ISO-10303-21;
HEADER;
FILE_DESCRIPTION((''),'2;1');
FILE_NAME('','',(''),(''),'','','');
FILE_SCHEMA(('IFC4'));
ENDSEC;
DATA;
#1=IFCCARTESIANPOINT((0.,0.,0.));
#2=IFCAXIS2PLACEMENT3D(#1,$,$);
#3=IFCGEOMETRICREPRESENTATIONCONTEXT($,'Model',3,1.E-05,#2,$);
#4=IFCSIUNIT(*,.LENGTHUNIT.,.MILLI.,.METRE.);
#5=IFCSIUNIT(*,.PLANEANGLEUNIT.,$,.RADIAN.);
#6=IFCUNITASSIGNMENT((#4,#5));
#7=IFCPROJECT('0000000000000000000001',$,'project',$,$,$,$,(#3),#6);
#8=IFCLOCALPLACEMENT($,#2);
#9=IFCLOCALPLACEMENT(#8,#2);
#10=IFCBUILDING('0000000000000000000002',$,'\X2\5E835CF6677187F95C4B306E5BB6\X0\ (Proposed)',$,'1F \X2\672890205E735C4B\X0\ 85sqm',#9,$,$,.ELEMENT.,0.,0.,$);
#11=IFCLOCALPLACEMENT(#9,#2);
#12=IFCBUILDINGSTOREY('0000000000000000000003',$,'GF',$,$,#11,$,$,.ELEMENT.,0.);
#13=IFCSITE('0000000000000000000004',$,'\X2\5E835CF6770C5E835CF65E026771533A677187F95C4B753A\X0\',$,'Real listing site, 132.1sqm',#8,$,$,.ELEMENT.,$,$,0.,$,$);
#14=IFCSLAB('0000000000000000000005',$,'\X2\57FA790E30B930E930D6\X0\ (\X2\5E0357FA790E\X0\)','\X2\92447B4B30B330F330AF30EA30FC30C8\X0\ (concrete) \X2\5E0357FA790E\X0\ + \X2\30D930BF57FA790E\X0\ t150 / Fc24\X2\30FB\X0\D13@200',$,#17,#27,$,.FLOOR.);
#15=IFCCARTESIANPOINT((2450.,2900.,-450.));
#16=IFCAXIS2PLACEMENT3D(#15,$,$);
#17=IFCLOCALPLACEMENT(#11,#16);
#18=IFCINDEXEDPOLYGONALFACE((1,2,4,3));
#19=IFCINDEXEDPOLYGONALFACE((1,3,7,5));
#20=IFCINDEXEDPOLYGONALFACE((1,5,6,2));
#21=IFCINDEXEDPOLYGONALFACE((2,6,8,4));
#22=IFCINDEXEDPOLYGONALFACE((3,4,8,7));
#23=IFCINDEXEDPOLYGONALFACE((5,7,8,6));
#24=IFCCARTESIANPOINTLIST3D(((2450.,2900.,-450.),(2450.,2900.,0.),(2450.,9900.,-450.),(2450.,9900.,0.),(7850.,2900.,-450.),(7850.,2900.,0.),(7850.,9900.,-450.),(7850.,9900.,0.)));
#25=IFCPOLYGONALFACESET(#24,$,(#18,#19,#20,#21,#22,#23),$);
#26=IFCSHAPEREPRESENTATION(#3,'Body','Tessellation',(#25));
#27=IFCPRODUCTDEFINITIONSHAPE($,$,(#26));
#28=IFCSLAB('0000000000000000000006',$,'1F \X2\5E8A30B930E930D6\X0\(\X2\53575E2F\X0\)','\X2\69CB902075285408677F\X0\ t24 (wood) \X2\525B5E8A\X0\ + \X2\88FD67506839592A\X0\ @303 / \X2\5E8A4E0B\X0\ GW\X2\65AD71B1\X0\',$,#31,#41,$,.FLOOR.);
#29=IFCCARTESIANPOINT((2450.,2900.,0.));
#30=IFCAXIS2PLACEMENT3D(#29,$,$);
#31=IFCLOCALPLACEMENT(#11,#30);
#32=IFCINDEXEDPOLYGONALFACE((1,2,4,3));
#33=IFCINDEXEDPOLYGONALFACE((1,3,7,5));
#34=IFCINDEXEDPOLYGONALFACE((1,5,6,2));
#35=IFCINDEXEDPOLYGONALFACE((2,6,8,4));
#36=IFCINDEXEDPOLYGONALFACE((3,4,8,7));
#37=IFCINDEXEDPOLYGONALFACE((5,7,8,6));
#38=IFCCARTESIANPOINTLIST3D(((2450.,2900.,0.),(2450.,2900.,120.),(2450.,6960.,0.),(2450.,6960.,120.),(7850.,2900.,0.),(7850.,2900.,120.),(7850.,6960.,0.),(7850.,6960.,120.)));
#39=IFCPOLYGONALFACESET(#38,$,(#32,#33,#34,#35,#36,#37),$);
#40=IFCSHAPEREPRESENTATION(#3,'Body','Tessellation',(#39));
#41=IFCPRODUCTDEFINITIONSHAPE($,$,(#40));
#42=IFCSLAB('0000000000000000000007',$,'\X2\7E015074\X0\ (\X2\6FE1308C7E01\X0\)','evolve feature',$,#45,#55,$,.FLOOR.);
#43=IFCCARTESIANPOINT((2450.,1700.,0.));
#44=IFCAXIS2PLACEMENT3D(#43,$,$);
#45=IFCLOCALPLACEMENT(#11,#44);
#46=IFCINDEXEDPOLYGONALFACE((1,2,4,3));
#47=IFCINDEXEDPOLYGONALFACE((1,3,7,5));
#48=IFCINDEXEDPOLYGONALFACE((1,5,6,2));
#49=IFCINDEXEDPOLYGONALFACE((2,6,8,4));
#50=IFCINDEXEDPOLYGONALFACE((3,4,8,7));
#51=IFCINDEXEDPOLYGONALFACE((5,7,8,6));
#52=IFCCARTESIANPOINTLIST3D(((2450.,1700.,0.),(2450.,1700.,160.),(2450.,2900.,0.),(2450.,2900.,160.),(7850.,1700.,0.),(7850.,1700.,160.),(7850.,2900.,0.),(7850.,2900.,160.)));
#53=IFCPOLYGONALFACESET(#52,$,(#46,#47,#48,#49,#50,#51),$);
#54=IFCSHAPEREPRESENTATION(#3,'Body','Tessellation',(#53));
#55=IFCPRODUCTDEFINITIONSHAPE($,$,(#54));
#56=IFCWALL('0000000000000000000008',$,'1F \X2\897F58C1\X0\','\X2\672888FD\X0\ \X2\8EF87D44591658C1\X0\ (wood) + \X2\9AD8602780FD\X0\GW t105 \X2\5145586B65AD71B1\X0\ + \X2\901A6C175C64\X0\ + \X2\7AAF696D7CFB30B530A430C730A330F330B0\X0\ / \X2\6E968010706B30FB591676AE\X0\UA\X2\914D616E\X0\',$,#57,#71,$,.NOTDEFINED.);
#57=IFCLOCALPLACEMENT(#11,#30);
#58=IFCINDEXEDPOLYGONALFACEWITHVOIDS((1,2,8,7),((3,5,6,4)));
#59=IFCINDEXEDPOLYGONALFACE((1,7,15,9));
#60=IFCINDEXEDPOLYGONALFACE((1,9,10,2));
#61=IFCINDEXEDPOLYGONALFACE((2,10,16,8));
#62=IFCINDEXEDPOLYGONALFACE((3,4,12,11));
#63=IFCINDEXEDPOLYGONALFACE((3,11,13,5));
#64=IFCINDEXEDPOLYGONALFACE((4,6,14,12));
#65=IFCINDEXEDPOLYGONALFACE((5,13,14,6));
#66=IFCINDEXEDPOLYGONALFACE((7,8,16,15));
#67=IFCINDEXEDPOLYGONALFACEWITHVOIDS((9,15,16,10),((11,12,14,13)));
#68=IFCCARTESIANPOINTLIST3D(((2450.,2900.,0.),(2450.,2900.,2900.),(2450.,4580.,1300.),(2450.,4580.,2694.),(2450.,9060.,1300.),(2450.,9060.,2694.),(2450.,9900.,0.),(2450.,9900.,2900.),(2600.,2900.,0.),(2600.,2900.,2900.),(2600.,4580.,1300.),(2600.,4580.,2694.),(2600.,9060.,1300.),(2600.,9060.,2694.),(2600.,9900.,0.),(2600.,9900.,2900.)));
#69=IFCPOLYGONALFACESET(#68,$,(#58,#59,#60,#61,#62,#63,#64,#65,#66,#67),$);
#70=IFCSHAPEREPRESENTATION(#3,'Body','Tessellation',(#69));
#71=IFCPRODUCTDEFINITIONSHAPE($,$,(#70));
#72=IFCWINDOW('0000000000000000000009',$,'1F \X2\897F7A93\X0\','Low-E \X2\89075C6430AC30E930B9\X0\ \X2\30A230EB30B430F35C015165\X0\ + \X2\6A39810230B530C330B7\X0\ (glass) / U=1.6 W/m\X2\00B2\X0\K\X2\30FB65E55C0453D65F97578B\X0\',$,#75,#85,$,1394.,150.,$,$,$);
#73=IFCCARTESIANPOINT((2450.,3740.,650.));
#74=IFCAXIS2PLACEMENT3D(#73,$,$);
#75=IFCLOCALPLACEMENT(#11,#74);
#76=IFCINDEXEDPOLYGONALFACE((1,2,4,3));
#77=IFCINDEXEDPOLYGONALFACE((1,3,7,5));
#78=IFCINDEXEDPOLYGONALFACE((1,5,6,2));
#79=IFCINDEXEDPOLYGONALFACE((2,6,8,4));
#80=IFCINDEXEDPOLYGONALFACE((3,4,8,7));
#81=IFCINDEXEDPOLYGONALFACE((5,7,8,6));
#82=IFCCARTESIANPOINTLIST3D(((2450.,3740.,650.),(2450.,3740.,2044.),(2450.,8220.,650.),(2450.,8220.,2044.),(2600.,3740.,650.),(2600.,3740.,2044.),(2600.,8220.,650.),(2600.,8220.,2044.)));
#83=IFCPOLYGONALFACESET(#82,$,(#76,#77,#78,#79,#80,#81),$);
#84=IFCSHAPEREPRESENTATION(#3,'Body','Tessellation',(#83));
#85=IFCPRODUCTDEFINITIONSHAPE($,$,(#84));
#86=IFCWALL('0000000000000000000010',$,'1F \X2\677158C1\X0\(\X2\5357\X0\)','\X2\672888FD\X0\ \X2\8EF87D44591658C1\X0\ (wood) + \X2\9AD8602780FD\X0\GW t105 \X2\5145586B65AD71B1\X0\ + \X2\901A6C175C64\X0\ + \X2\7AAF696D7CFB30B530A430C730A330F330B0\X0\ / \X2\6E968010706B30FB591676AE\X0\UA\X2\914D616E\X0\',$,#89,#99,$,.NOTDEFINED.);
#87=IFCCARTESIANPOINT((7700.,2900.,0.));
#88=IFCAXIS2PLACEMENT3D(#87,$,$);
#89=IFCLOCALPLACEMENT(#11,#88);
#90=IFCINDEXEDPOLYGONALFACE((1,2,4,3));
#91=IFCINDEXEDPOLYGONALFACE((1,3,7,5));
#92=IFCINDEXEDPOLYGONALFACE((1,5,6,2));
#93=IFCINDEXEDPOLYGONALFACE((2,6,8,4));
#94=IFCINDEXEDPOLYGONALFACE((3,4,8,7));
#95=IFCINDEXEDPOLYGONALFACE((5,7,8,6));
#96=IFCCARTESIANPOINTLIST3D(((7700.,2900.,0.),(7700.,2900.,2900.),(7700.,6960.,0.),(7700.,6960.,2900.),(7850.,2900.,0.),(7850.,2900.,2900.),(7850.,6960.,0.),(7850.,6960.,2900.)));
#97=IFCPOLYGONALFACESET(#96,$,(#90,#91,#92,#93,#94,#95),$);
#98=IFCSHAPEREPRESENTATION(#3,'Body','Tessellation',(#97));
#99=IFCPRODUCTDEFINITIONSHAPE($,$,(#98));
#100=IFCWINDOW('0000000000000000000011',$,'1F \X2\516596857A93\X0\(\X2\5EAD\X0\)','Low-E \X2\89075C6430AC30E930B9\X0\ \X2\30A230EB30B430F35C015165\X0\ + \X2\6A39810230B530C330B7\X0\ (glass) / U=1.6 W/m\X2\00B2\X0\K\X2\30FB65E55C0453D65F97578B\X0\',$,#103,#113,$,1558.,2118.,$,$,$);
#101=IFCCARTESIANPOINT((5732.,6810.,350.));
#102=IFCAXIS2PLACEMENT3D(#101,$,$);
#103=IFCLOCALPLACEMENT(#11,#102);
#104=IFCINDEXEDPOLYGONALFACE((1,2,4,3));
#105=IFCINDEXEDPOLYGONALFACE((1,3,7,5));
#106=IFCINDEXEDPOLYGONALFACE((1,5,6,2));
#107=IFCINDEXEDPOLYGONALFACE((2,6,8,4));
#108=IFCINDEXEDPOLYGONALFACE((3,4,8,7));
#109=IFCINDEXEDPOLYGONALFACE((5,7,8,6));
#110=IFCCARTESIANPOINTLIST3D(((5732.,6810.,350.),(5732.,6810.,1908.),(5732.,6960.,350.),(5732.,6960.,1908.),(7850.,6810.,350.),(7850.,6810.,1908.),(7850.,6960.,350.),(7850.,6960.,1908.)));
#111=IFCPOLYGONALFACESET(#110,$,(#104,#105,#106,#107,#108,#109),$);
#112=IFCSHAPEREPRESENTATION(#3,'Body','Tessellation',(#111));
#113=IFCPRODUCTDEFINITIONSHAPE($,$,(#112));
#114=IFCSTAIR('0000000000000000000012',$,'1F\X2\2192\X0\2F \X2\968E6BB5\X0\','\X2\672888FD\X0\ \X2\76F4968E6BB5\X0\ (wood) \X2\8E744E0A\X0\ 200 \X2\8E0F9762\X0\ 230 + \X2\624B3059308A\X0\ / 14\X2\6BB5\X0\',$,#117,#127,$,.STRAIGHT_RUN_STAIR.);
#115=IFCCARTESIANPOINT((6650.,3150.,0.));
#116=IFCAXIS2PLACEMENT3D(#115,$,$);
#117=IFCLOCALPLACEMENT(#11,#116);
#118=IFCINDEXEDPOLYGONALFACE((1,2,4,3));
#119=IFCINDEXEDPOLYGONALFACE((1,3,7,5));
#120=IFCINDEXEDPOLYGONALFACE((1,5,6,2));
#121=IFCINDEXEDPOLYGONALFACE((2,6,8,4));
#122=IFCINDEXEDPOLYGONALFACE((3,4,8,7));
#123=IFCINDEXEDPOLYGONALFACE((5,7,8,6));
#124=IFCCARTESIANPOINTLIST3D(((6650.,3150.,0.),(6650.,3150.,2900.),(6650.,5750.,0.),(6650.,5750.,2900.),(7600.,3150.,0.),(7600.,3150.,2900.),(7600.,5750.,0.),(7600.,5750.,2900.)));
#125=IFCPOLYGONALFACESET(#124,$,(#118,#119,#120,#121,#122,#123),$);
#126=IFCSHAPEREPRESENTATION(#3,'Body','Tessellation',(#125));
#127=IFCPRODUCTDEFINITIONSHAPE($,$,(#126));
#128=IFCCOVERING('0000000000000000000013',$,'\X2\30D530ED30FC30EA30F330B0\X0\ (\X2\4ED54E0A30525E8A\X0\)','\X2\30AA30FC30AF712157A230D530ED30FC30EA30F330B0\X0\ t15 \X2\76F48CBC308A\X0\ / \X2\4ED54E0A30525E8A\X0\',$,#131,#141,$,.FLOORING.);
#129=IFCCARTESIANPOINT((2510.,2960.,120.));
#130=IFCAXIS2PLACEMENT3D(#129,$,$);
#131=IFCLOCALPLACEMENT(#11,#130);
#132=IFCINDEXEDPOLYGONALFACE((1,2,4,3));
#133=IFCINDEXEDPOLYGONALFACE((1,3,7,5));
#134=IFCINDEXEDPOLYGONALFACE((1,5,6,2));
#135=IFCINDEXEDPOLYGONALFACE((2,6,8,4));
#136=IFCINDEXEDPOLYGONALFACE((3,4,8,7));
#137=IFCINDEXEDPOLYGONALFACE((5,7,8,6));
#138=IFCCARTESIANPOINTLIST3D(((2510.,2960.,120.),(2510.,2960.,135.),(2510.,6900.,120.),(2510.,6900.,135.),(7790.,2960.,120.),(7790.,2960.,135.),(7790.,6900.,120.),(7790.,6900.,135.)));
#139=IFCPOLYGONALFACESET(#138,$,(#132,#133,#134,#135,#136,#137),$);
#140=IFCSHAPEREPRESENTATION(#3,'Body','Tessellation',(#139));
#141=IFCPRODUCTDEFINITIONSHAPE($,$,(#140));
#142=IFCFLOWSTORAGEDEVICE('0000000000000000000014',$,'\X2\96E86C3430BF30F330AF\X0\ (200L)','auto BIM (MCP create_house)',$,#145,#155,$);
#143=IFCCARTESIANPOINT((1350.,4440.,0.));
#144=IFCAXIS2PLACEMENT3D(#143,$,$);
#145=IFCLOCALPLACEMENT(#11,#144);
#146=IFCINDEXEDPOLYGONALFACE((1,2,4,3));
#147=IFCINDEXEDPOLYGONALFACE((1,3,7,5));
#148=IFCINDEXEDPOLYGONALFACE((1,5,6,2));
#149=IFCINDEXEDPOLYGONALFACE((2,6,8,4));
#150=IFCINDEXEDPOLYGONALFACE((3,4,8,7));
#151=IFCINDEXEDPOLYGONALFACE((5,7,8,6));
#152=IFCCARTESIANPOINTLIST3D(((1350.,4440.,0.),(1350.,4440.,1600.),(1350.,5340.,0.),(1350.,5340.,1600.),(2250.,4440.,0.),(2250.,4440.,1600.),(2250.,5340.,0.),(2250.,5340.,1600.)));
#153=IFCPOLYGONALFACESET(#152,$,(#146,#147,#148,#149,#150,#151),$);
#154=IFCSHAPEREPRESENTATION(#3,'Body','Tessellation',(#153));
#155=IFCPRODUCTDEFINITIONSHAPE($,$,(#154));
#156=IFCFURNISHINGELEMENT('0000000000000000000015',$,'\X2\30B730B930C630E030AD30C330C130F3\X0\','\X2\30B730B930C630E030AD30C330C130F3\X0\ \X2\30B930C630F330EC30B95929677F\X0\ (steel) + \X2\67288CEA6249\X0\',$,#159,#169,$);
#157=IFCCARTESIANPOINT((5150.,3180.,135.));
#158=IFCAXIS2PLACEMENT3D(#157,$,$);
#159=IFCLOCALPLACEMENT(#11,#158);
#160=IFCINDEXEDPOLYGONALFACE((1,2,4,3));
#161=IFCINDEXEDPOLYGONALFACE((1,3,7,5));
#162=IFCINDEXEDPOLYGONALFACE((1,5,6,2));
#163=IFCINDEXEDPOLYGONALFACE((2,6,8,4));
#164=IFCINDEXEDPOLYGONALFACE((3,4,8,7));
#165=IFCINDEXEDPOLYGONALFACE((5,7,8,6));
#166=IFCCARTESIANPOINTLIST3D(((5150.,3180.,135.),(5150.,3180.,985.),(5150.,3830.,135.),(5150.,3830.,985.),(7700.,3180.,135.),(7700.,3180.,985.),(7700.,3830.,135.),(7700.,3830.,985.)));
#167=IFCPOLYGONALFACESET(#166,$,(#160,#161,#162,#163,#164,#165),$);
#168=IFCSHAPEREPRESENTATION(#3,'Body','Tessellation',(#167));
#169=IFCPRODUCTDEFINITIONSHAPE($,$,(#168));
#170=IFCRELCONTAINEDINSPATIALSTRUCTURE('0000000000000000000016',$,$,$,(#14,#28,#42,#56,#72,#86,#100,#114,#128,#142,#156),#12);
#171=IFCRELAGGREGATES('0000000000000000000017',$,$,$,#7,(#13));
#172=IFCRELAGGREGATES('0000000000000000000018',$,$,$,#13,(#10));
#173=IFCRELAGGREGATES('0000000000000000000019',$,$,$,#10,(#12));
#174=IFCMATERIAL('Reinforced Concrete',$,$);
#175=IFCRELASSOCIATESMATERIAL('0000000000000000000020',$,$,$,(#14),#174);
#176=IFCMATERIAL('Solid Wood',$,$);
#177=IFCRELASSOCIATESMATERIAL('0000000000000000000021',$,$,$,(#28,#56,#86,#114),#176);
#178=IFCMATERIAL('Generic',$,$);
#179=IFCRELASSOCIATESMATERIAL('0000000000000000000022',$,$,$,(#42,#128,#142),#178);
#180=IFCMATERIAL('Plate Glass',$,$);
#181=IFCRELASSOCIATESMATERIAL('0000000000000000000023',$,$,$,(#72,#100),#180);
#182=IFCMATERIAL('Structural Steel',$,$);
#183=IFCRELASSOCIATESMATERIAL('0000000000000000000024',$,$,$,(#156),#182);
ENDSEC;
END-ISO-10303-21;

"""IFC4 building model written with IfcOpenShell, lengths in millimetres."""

from ifc_helpers import new_model, si_unit, frame, frame_2d, origin, place, context, project, spatial, rectangle, extrude, material, element, fill, save


model = new_model("IFC4")

# Units and contexts
model_context = context("Model", 3, precision=1e-05, world=origin())
ifc_project = project(units=[si_unit("LENGTHUNIT", "METRE", prefix="MILLI"), si_unit("PLANEANGLEUNIT", "RADIAN")], contexts=[model_context])

# Site, building, storey
site_placement = place(None, origin())
site = spatial("IfcSite", under=ifc_project, at=site_placement, Name="広島県広島市東区東蟹屋町", ObjectType="Real listing site, 132.1sqm", CompositionType="ELEMENT", RefElevation=0.0)
building_placement = place(site_placement, origin())
building = spatial("IfcBuilding", under=site, at=building_placement, Name="広島東蟹屋の家 (Proposed)", ObjectType="1F 木造平屋 85sqm", CompositionType="ELEMENT", ElevationOfRefHeight=0.0, ElevationOfTerrain=0.0)
storey_placement = place(building_placement, origin())
storey = spatial("IfcBuildingStorey", under=building, at=storey_placement, Name="GF", CompositionType="ELEMENT", Elevation=0.0)

# Slabs
ifc_material_1 = material(Name="Reinforced Concrete")
slab_1_placement = place(storey_placement, frame((2450.0, 2900.0, -450.0)))
element("IfcSlab", 1, at=slab_1_placement, inside=storey, material=ifc_material_1, Name="基礎スラブ (布基礎)", Description="鉄筋コンクリート (concrete) 布基礎 + ベタ基礎 t150 / Fc24・D13@200", PredefinedType="FLOOR", context=model_context, shape_type="SweptSolid", body=[
    extrude(rectangle(XDim=5400.0, YDim=7000.0, at=frame_2d((2700.0, 3500.0))), frame((2450.0, 2900.0, -450.0)), (0.0, 0.0, 1.0), 450.0),
])
ifc_material_2 = material(Name="Solid Wood")
slab_2_placement = place(storey_placement, frame((2450.0, 2900.0, 0.0)))
element("IfcSlab", 2, at=slab_2_placement, inside=storey, material=ifc_material_2, Name="1F 床スラブ(南帯)", Description="構造用合板 t24 (wood) 剛床 + 製材根太 @303 / 床下 GW断熱", PredefinedType="FLOOR", context=model_context, shape_type="SweptSolid", body=[
    extrude(rectangle(XDim=5400.0, YDim=4060.0, at=frame_2d((2700.0, 2030.0))), frame((2450.0, 2900.0, 0.0)), (0.0, 0.0, 1.0), 120.0),
])
ifc_material_3 = material(Name="Generic")
slab_3_placement = place(storey_placement, frame((2450.0, 1700.0, 0.0)))
element("IfcSlab", 3, at=slab_3_placement, inside=storey, material=ifc_material_3, Name="縁側 (濡れ縁)", Description="evolve feature", PredefinedType="FLOOR", context=model_context, shape_type="SweptSolid", body=[
    extrude(rectangle(XDim=5400.0, YDim=1200.0, at=frame_2d((2700.0, 600.0))), frame((2450.0, 1700.0, 0.0)), (0.0, 0.0, 1.0), 160.0),
])

# Shared definitions
ifc_material_4 = material(Name="Plate Glass")

# Walls, openings, windows
wall_1_placement = place(storey_placement, frame((2450.0, 2900.0, 0.0)))
wall_1 = element("IfcWall", 4, at=wall_1_placement, inside=storey, material=ifc_material_2, Name="1F 西壁", Description="木製 軸組外壁 (wood) + 高性能GW t105 充填断熱 + 通気層 + 窯業系サイディング / 準耐火・外皮UA配慮", PredefinedType="NOTDEFINED", context=model_context, shape_type="SweptSolid", body=[
    extrude(rectangle(XDim=150.0, YDim=7000.0, at=frame_2d((75.0, 3500.0))), frame((2450.0, 2900.0, 0.0)), (0.0, 0.0, 1.0), 2900.0),
])
opening_1_placement = place(storey_placement, frame((2450.0, 3740.0, 650.0)))
opening_1 = element("IfcOpeningElement", 5, at=opening_1_placement, cuts=wall_1, PredefinedType="NOTDEFINED", context=model_context, shape_type="SweptSolid", body=[
    extrude(rectangle(XDim=150.0, YDim=4480.0, at=frame_2d((75.0, 2240.0))), frame((2450.0, 3740.0, 650.0)), (0.0, 0.0, 1.0), 1394.0),
])
window_1_placement = place(storey_placement, frame((2450.0, 3740.0, 650.0)))
window_1 = element("IfcWindow", 6, at=window_1_placement, inside=storey, material=ifc_material_4, Name="1F 西窓", Description="Low-E 複層ガラス アルゴン封入 + 樹脂サッシ (glass) / U=1.6 W/m²K・日射取得型", OverallHeight=1394.0, OverallWidth=150.0, context=model_context, shape_type="SweptSolid", body=[
    extrude(rectangle(XDim=150.0, YDim=4480.0, at=frame_2d((75.0, 2240.0))), frame((2450.0, 3740.0, 650.0)), (0.0, 0.0, 1.0), 1394.0),
])
fill(opening_1, window_1)
wall_2_placement = place(storey_placement, frame((7700.0, 2900.0, 0.0)))
wall_2 = element("IfcWall", 7, at=wall_2_placement, inside=storey, material=ifc_material_2, Name="1F 東壁(南)", Description="木製 軸組外壁 (wood) + 高性能GW t105 充填断熱 + 通気層 + 窯業系サイディング / 準耐火・外皮UA配慮", PredefinedType="NOTDEFINED", context=model_context, shape_type="SweptSolid", body=[
    extrude(rectangle(XDim=150.0, YDim=4060.0, at=frame_2d((75.0, 2030.0))), frame((7700.0, 2900.0, 0.0)), (0.0, 0.0, 1.0), 2900.0),
])
opening_2_placement = place(storey_placement, frame((5732.0, 6810.0, 350.0)))
opening_2 = element("IfcOpeningElement", 8, at=opening_2_placement, cuts=wall_2, PredefinedType="NOTDEFINED", context=model_context, shape_type="SweptSolid", body=[
    extrude(rectangle(XDim=2118.0, YDim=150.0, at=frame_2d((1059.0, 75.0))), frame((5732.0, 6810.0, 350.0)), (0.0, 0.0, 1.0), 1558.0),
])
window_2_placement = place(storey_placement, frame((5732.0, 6810.0, 350.0)))
window_2 = element("IfcWindow", 9, at=window_2_placement, inside=storey, material=ifc_material_4, Name="1F 入隅窓(庭)", Description="Low-E 複層ガラス アルゴン封入 + 樹脂サッシ (glass) / U=1.6 W/m²K・日射取得型", OverallHeight=1558.0, OverallWidth=2118.0, context=model_context, shape_type="SweptSolid", body=[
    extrude(rectangle(XDim=2118.0, YDim=150.0, at=frame_2d((1059.0, 75.0))), frame((5732.0, 6810.0, 350.0)), (0.0, 0.0, 1.0), 1558.0),
])
fill(opening_2, window_2)

# Stair
stair_placement = place(storey_placement, frame((6650.0, 3150.0, 0.0)))
element("IfcStair", 10, at=stair_placement, inside=storey, material=ifc_material_2, Name="1F→2F 階段", Description="木製 直階段 (wood) 蹴上 200 踏面 230 + 手すり / 14段", PredefinedType="STRAIGHT_RUN_STAIR", context=model_context, shape_type="SweptSolid", body=[
    extrude(rectangle(XDim=950.0, YDim=2600.0, at=frame_2d((475.0, 1300.0))), frame((6650.0, 3150.0, 0.0)), (0.0, 0.0, 1.0), 2900.0),
])

# Covering
covering_placement = place(storey_placement, frame((2510.0, 2960.0, 120.0)))
element("IfcCovering", 11, at=covering_placement, inside=storey, material=ifc_material_3, Name="フローリング (仕上げ床)", Description="オーク無垢フローリング t15 直貼り / 仕上げ床", PredefinedType="FLOORING", context=model_context, shape_type="SweptSolid", body=[
    extrude(rectangle(XDim=5280.0, YDim=3940.0, at=frame_2d((2640.0, 1970.0))), frame((2510.0, 2960.0, 120.0)), (0.0, 0.0, 1.0), 15.0),
])

# Flow storage device
flow_storage_device_placement = place(storey_placement, frame((1350.0, 4440.0, 0.0)))
element("IfcFlowStorageDevice", 12, at=flow_storage_device_placement, inside=storey, material=ifc_material_3, Name="雨水タンク (200L)", Description="auto BIM (MCP create_house)", context=model_context, shape_type="SweptSolid", body=[
    extrude(rectangle(XDim=900.0, YDim=900.0, at=frame_2d((450.0, 450.0))), frame((1350.0, 4440.0, 0.0)), (0.0, 0.0, 1.0), 1600.0),
])

# Furnishing element
ifc_material_5 = material(Name="Structural Steel")
furnishing_placement = place(storey_placement, frame((5150.0, 3180.0, 135.0)))
element("IfcFurnishingElement", 13, at=furnishing_placement, inside=storey, material=ifc_material_5, Name="システムキッチン", Description="システムキッチン ステンレス天板 (steel) + 木質扉", context=model_context, shape_type="SweptSolid", body=[
    extrude(rectangle(XDim=2550.0, YDim=650.0, at=frame_2d((1275.0, 325.0))), frame((5150.0, 3180.0, 135.0)), (0.0, 0.0, 1.0), 850.0),
])

save(model, "model.ifc")
